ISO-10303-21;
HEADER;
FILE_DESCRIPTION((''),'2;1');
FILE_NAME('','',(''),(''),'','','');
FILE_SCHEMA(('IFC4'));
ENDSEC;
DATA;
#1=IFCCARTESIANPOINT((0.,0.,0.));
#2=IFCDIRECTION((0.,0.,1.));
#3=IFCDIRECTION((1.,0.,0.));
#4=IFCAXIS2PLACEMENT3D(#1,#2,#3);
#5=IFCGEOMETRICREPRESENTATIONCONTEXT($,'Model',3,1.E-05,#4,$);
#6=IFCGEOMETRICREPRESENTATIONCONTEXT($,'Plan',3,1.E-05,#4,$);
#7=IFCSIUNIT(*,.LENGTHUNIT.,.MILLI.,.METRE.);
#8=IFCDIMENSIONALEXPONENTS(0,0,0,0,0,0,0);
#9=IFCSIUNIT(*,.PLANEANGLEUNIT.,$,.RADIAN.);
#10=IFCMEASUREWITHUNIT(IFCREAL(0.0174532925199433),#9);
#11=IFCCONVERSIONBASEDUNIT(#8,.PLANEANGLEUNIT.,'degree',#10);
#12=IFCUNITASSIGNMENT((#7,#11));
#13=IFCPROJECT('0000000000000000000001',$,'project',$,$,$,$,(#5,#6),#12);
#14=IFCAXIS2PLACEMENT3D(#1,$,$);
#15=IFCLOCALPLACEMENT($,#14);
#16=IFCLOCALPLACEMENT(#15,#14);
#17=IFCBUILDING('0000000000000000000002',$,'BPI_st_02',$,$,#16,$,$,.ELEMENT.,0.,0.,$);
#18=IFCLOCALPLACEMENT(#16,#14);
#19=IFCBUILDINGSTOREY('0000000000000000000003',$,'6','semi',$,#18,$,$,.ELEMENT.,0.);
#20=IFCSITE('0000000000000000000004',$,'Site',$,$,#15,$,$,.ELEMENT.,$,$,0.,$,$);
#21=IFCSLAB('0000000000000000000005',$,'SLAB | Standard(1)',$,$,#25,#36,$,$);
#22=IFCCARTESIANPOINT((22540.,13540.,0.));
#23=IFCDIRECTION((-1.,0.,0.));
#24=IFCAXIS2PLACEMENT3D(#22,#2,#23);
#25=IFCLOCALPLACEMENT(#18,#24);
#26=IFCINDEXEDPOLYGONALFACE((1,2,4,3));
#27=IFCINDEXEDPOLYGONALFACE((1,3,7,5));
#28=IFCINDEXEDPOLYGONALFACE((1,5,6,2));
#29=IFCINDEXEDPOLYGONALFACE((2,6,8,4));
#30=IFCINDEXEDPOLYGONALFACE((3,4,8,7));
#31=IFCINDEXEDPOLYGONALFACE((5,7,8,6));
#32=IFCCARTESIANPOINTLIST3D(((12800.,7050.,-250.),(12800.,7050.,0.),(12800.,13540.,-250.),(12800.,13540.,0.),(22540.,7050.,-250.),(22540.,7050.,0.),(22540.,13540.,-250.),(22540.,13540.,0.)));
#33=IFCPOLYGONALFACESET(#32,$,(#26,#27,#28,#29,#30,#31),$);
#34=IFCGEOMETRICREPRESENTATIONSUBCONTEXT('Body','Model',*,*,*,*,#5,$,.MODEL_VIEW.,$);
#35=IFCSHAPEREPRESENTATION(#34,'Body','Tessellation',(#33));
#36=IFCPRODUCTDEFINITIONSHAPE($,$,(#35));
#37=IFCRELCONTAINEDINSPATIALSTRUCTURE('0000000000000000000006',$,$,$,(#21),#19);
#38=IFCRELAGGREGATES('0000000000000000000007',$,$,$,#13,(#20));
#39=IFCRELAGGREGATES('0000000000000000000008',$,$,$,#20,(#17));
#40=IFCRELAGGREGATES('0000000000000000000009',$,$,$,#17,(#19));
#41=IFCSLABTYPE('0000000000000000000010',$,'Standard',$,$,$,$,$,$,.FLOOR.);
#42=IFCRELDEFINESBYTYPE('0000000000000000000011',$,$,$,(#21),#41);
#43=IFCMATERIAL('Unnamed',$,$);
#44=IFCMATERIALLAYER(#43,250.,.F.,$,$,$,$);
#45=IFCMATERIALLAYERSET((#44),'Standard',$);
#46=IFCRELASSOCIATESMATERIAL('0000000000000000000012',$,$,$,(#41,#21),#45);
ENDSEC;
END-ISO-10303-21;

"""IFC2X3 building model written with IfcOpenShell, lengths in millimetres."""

from ifc_helpers import new_model, entity, si_unit, converted_unit, frame, frame_2d, origin, origin_with_axes, place, context, subcontext, project, spatial, rectangle, extrude, material, layer, layer_set, layer_usage, type_object, element, save


model = new_model("IFC2X3")

# Units and contexts
model_context = context("Model", 3, precision=1e-05, world=origin_with_axes())
plan_context = context("Plan", 3, precision=1e-05, world=origin_with_axes())
body_context = subcontext(model_context, "Body", "Model", "MODEL_VIEW")
ifc_project = project(units=[si_unit("LENGTHUNIT", "METRE", prefix="MILLI"), converted_unit("PLANEANGLEUNIT", "degree", entity("IfcReal", 0.0174532925199433), si_unit("PLANEANGLEUNIT", "RADIAN"), dimensions=[0, 0, 0, 0, 0, 0, 0])], contexts=[model_context, plan_context])

# Site, building, storey
site_placement = place(None, origin())
site = spatial("IfcSite", under=ifc_project, at=site_placement, Name="Site", CompositionType="ELEMENT", RefElevation=0.0)
building_placement = place(site_placement, origin())
building = spatial("IfcBuilding", under=site, at=building_placement, Name="BPI_st_02", CompositionType="ELEMENT", ElevationOfRefHeight=0.0, ElevationOfTerrain=0.0)
storey_placement = place(building_placement, origin())
storey = spatial("IfcBuildingStorey", under=building, at=storey_placement, Name="6", Description="semi", CompositionType="ELEMENT", Elevation=0.0)

# Slab
ifc_material = material(Name="Unnamed")
ifc_layer_1 = layer(ifc_material, 250.0, ventilated=False)
ifc_layer_set_1 = layer_set([ifc_layer_1], Name="Standard")
ifc_layer_usage_1 = layer_usage(ifc_layer_set_1, "AXIS3", "POSITIVE", 0.0)
slab_type = type_object("IfcSlabType", Name="Standard", PredefinedType="FLOOR", material=ifc_layer_set_1)
slab_placement = place(storey_placement, frame((22540.0, 13540.0, 0.0), z_axis=(0.0, 0.0, 1.0), x_axis=(-1.0, 0.0, 0.0)))
element("IfcSlab", 1, at=slab_placement, inside=storey, type_object=slab_type, material=ifc_layer_usage_1, Name="SLAB | Standard(1)", context=body_context, shape_type="SweptSolid", body=[
    extrude(rectangle(XDim=9740.0, YDim=6490.0, at=frame_2d((17670.0, 10295.0), x_axis=(1.0, 0.0))), frame((0.0, 0.0, -250.0)), (0.0, 0.0, 1.0), 250.0),
])

save(model, "model.ifc")
